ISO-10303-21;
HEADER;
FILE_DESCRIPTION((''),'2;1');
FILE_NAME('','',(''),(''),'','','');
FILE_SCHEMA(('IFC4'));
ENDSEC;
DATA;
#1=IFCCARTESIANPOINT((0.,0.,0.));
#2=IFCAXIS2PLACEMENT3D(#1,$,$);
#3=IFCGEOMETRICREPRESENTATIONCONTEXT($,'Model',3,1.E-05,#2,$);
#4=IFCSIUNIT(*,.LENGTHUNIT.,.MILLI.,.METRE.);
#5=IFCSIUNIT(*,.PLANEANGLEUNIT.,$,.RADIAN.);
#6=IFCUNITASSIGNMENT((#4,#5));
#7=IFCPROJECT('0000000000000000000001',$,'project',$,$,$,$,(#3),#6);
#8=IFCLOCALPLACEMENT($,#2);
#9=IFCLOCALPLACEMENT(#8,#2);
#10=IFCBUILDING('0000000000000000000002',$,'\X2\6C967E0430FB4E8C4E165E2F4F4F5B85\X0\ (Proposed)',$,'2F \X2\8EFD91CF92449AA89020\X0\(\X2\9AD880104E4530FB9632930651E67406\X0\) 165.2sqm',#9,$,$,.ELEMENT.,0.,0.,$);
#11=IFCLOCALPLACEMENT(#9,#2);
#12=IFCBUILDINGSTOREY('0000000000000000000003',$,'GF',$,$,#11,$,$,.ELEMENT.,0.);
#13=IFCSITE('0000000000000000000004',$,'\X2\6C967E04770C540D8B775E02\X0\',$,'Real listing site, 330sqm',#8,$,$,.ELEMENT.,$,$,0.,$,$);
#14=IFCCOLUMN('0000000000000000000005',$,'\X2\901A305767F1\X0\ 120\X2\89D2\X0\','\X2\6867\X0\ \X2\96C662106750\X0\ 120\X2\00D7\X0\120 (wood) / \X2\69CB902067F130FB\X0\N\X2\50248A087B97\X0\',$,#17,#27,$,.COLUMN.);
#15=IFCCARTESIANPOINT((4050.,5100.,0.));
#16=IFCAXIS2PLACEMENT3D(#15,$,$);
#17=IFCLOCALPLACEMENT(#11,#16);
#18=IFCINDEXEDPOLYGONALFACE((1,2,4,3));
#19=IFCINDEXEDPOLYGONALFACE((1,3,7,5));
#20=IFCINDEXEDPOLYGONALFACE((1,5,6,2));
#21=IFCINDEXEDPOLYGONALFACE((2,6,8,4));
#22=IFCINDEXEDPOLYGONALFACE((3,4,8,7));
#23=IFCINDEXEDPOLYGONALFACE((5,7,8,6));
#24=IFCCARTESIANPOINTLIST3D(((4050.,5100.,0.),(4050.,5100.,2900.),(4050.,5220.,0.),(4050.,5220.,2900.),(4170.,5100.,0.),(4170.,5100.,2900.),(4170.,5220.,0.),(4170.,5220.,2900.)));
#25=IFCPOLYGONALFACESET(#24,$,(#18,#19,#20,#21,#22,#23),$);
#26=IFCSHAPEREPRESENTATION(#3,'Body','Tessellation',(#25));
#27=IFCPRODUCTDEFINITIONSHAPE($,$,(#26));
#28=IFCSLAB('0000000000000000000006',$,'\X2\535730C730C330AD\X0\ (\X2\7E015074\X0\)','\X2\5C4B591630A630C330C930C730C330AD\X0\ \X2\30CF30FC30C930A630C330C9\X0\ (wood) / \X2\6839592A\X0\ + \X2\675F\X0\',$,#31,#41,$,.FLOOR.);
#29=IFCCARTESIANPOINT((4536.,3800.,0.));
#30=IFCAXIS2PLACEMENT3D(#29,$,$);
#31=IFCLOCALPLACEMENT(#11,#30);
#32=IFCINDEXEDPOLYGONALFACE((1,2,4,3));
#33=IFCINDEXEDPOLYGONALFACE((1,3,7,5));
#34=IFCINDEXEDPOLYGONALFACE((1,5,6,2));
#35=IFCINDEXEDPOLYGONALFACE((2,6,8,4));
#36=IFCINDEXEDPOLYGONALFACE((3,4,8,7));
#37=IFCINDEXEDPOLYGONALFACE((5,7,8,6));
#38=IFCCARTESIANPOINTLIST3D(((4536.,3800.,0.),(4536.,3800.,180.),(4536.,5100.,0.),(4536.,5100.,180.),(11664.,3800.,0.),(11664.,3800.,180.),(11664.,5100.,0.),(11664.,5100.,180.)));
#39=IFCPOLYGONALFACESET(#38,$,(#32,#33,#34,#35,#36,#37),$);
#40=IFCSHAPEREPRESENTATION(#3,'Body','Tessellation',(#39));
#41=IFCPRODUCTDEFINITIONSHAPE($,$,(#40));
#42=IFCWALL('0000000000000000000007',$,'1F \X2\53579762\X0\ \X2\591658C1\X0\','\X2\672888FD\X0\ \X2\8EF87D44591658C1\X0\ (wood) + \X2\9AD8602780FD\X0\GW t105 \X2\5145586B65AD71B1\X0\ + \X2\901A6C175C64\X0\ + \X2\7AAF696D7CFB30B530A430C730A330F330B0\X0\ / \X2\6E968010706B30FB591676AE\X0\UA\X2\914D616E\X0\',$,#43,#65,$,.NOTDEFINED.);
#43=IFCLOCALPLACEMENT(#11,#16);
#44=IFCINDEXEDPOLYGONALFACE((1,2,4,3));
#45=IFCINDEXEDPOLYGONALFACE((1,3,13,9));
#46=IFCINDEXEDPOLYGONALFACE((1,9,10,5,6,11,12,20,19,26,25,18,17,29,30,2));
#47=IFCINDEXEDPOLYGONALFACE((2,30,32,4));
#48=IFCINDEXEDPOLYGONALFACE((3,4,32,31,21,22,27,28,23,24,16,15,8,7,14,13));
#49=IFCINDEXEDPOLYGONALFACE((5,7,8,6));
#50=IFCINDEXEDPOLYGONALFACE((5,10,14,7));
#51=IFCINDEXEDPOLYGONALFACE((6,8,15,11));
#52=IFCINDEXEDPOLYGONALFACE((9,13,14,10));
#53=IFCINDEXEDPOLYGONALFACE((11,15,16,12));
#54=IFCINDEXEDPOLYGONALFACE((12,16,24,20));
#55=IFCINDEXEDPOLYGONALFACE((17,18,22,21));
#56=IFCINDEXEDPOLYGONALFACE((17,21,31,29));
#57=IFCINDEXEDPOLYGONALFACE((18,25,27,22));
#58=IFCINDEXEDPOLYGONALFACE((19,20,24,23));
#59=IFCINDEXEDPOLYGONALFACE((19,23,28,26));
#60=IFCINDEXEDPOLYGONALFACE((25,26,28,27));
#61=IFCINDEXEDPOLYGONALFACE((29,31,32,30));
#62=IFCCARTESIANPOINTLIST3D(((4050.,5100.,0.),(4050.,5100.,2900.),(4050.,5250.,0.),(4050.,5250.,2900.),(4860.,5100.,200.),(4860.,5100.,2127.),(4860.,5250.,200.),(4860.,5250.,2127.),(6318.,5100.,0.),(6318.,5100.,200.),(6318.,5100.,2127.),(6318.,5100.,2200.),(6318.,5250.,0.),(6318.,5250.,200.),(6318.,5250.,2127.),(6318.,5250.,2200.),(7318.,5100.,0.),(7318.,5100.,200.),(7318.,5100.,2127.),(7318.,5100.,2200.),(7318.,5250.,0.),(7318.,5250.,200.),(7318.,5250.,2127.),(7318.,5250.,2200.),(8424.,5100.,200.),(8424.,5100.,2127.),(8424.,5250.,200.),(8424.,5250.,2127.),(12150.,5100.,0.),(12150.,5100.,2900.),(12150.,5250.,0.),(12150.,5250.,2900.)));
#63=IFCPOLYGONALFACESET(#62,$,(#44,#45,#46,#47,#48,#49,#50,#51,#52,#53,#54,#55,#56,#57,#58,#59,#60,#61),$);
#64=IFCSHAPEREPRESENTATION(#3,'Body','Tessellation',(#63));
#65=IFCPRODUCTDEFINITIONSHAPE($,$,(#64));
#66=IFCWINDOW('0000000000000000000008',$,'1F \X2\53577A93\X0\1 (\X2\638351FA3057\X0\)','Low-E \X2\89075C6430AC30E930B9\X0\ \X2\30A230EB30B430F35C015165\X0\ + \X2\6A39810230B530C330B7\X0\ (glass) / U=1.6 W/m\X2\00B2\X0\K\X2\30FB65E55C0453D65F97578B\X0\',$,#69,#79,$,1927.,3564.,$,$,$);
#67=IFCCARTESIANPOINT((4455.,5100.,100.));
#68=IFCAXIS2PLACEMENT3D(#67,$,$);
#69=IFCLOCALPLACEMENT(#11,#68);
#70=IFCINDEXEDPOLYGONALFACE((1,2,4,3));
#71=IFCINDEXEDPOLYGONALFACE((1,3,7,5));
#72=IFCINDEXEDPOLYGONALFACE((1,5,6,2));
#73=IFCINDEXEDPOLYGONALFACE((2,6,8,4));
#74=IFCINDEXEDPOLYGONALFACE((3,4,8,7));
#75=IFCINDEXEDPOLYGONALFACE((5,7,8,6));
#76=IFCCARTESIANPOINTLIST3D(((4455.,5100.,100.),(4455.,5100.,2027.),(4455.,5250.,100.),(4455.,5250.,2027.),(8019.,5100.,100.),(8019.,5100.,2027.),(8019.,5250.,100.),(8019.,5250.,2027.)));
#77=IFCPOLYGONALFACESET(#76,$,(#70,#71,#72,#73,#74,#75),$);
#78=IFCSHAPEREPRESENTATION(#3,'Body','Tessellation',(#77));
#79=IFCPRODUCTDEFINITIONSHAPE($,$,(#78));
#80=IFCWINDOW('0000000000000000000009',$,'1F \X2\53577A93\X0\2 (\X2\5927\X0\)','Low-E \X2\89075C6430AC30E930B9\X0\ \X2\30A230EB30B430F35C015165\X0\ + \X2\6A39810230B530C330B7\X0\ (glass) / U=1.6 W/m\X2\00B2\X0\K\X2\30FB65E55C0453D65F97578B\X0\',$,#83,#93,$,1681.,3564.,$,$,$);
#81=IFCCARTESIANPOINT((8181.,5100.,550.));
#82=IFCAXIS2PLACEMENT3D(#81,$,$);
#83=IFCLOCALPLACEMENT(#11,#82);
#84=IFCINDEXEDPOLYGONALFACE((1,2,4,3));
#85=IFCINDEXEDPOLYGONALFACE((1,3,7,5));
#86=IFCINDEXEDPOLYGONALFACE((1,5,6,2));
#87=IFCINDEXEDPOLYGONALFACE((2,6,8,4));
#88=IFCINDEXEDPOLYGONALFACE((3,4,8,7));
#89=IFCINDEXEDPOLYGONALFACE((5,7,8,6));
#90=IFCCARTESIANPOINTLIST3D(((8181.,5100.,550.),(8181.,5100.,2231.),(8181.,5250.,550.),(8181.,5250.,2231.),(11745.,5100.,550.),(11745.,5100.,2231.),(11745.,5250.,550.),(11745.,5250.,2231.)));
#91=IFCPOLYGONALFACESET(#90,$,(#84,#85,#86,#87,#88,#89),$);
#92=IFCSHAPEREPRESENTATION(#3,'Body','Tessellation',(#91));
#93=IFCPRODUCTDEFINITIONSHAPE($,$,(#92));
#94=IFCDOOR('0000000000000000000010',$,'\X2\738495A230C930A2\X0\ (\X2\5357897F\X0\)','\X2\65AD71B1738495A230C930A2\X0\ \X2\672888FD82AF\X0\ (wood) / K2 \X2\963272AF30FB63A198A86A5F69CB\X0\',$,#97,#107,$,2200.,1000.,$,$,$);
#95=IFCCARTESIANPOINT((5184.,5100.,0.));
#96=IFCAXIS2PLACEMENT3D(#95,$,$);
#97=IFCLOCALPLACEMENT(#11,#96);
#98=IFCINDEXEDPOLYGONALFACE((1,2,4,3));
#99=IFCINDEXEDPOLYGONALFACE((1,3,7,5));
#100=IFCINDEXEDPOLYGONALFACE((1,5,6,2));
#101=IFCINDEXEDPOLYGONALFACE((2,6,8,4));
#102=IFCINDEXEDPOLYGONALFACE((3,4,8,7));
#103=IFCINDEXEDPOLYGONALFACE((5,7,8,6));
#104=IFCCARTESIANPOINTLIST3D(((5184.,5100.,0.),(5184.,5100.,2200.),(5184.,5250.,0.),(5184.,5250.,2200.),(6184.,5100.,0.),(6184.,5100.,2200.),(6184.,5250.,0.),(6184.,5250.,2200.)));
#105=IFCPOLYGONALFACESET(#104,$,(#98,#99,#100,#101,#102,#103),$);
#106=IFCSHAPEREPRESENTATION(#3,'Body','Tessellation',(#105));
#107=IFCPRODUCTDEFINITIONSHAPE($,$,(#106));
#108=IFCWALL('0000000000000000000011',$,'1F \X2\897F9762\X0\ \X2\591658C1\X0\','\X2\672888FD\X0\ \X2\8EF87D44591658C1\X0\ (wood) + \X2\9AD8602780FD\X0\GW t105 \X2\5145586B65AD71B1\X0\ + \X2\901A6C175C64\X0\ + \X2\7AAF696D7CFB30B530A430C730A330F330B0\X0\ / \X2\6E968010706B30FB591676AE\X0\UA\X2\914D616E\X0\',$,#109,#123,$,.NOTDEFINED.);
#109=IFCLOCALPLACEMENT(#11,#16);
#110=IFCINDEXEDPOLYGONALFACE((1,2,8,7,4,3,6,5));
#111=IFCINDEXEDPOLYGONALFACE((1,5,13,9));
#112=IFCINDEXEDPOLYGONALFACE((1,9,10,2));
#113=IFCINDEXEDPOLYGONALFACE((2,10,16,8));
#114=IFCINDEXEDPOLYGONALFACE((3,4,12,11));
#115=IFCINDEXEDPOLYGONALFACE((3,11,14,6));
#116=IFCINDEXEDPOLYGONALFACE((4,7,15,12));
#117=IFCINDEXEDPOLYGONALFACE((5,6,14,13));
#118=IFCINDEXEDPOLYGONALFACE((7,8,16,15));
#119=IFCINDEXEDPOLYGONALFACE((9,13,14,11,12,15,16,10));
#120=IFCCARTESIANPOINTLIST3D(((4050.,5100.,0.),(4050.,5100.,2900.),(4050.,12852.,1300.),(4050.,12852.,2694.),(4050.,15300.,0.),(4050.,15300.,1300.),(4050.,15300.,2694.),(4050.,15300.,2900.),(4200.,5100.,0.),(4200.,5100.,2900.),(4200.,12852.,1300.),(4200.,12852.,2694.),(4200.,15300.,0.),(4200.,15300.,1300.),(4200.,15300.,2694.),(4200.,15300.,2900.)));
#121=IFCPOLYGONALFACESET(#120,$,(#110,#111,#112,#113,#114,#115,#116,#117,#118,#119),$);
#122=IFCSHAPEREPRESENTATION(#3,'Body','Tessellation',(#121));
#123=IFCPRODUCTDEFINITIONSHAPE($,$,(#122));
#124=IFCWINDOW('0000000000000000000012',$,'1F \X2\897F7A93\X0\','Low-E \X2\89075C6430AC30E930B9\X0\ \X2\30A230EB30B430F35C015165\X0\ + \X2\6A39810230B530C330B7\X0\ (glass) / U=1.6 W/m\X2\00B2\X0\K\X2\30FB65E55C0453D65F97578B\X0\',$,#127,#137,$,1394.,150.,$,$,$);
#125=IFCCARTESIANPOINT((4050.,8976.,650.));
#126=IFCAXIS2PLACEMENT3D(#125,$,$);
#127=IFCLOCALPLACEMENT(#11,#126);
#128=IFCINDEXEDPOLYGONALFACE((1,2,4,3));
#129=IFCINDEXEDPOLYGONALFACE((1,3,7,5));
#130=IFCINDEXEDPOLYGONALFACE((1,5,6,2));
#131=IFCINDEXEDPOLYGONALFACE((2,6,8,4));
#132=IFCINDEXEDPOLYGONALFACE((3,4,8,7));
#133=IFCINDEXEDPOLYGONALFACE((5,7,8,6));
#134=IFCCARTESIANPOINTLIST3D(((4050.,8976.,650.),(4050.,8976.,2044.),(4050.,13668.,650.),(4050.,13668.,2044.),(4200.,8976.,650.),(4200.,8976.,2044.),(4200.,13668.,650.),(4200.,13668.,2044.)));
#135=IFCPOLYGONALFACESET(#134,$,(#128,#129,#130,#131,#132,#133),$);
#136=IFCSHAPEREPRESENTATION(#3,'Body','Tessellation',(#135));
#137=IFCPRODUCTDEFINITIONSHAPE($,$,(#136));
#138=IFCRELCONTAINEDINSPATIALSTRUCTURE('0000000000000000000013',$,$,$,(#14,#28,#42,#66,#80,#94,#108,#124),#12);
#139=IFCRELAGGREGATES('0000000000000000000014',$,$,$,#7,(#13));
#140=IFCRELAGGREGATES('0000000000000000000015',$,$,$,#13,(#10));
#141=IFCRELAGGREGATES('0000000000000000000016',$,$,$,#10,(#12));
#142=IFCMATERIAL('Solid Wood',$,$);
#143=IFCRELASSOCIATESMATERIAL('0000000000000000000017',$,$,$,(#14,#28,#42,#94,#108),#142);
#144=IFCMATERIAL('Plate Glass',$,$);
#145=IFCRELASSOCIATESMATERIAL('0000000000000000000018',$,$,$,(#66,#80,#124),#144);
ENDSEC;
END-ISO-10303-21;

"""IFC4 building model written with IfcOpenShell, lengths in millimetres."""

from ifc_helpers import new_model, si_unit, frame, frame_2d, origin, place, context, project, spatial, rectangle, extrude, material, element, fill, save


model = new_model("IFC4")

# Units and contexts
model_context = context("Model", 3, precision=1e-05, world=origin())
ifc_project = project(units=[si_unit("LENGTHUNIT", "METRE", prefix="MILLI"), si_unit("PLANEANGLEUNIT", "RADIAN")], contexts=[model_context])

# Site, building, storey
site_placement = place(None, origin())
site = spatial("IfcSite", under=ifc_project, at=site_placement, Name="沖縄県名護市", ObjectType="Real listing site, 330sqm", CompositionType="ELEMENT", RefElevation=0.0)
building_placement = place(site_placement, origin())
building = spatial("IfcBuilding", under=site, at=building_placement, Name="沖縄・二世帯住宅 (Proposed)", ObjectType="2F 軽量鉄骨造(高耐久・防錆処理) 165.2sqm", CompositionType="ELEMENT", ElevationOfRefHeight=0.0, ElevationOfTerrain=0.0)
storey_placement = place(building_placement, origin())
storey = spatial("IfcBuildingStorey", under=building, at=storey_placement, Name="GF", CompositionType="ELEMENT", Elevation=0.0)

# Column
ifc_material_1 = material(Name="Solid Wood")
column_placement = place(storey_placement, frame((4050.0, 5100.0, 0.0)))
element("IfcColumn", 1, at=column_placement, inside=storey, material=ifc_material_1, Name="通し柱 120角", Description="桧 集成材 120×120 (wood) / 構造柱・N値計算", PredefinedType="COLUMN", context=model_context, shape_type="SweptSolid", body=[
    extrude(rectangle(XDim=120.0, YDim=120.0, at=frame_2d((60.0, 60.0))), frame((4050.0, 5100.0, 0.0)), (0.0, 0.0, 1.0), 2900.0),
])

# Slab
slab_1_placement = place(storey_placement, frame((4536.0, 3800.0, 0.0)))
element("IfcSlab", 2, at=slab_1_placement, inside=storey, material=ifc_material_1, Name="南デッキ (縁側)", Description="屋外ウッドデッキ ハードウッド (wood) / 根太 + 束", PredefinedType="FLOOR", context=model_context, shape_type="SweptSolid", body=[
    extrude(rectangle(XDim=7128.0, YDim=1300.0, at=frame_2d((3564.0, 650.0))), frame((4536.0, 3800.0, 0.0)), (0.0, 0.0, 1.0), 180.0),
])

# Wall, openings, windows, door
wall_1_placement = place(storey_placement, frame((4050.0, 5100.0, 0.0)))
wall_1 = element("IfcWall", 3, at=wall_1_placement, inside=storey, material=ifc_material_1, Name="1F 南面 外壁", Description="木製 軸組外壁 (wood) + 高性能GW t105 充填断熱 + 通気層 + 窯業系サイディング / 準耐火・外皮UA配慮", PredefinedType="NOTDEFINED", context=model_context, shape_type="SweptSolid", body=[
    extrude(rectangle(XDim=8100.0, YDim=150.0, at=frame_2d((4050.0, 75.0))), frame((4050.0, 5100.0, 0.0)), (0.0, 0.0, 1.0), 2900.0),
])
opening_1_placement = place(storey_placement, frame((4455.0, 5100.0, 100.0)))
opening_1 = element("IfcOpeningElement", 4, at=opening_1_placement, cuts=wall_1, PredefinedType="NOTDEFINED", context=model_context, shape_type="SweptSolid", body=[
    extrude(rectangle(XDim=3564.0, YDim=150.0, at=frame_2d((1782.0, 75.0))), frame((4455.0, 5100.0, 100.0)), (0.0, 0.0, 1.0), 1927.0),
])
opening_2_placement = place(storey_placement, frame((8181.0, 5100.0, 550.0)))
opening_2 = element("IfcOpeningElement", 5, at=opening_2_placement, cuts=wall_1, PredefinedType="NOTDEFINED", context=model_context, shape_type="SweptSolid", body=[
    extrude(rectangle(XDim=3564.0, YDim=150.0, at=frame_2d((1782.0, 75.0))), frame((8181.0, 5100.0, 550.0)), (0.0, 0.0, 1.0), 1681.0),
])
opening_3_placement = place(storey_placement, frame((5184.0, 5100.0, 0.0)))
opening_3 = element("IfcOpeningElement", 6, at=opening_3_placement, cuts=wall_1, PredefinedType="NOTDEFINED", context=model_context, shape_type="SweptSolid", body=[
    extrude(rectangle(XDim=1000.0, YDim=150.0, at=frame_2d((500.0, 75.0))), frame((5184.0, 5100.0, 0.0)), (0.0, 0.0, 1.0), 2200.0),
])
ifc_material_2 = material(Name="Plate Glass")
window_1_placement = place(storey_placement, frame((4455.0, 5100.0, 100.0)))
window_1 = element("IfcWindow", 7, at=window_1_placement, inside=storey, material=ifc_material_2, Name="1F 南窓1 (掃出し)", Description="Low-E 複層ガラス アルゴン封入 + 樹脂サッシ (glass) / U=1.6 W/m²K・日射取得型", OverallHeight=1927.0, OverallWidth=3564.0, context=model_context, shape_type="SweptSolid", body=[
    extrude(rectangle(XDim=3564.0, YDim=150.0, at=frame_2d((1782.0, 75.0))), frame((4455.0, 5100.0, 100.0)), (0.0, 0.0, 1.0), 1927.0),
])
fill(opening_1, window_1)
window_2_placement = place(storey_placement, frame((8181.0, 5100.0, 550.0)))
window_2 = element("IfcWindow", 8, at=window_2_placement, inside=storey, material=ifc_material_2, Name="1F 南窓2 (大)", Description="Low-E 複層ガラス アルゴン封入 + 樹脂サッシ (glass) / U=1.6 W/m²K・日射取得型", OverallHeight=1681.0, OverallWidth=3564.0, context=model_context, shape_type="SweptSolid", body=[
    extrude(rectangle(XDim=3564.0, YDim=150.0, at=frame_2d((1782.0, 75.0))), frame((8181.0, 5100.0, 550.0)), (0.0, 0.0, 1.0), 1681.0),
])
fill(opening_2, window_2)
door_placement = place(storey_placement, frame((5184.0, 5100.0, 0.0)))
door = element("IfcDoor", 9, at=door_placement, inside=storey, material=ifc_material_1, Name="玄関ドア (南西)", Description="断熱玄関ドア 木製芯 (wood) / K2 防犯・採風機構", OverallHeight=2200.0, OverallWidth=1000.0, context=model_context, shape_type="SweptSolid", body=[
    extrude(rectangle(XDim=1000.0, YDim=150.0, at=frame_2d((500.0, 75.0))), frame((5184.0, 5100.0, 0.0)), (0.0, 0.0, 1.0), 2200.0),
])
fill(opening_3, door)

# Wall, opening, window
wall_2_placement = place(storey_placement, frame((4050.0, 5100.0, 0.0)))
wall_2 = element("IfcWall", 10, at=wall_2_placement, inside=storey, material=ifc_material_1, Name="1F 西面 外壁", Description="木製 軸組外壁 (wood) + 高性能GW t105 充填断熱 + 通気層 + 窯業系サイディング / 準耐火・外皮UA配慮", PredefinedType="NOTDEFINED", context=model_context, shape_type="SweptSolid", body=[
    extrude(rectangle(XDim=150.0, YDim=10200.0, at=frame_2d((75.0, 5100.0))), frame((4050.0, 5100.0, 0.0)), (0.0, 0.0, 1.0), 2900.0),
])
opening_4_placement = place(storey_placement, frame((4050.0, 8976.0, 650.0)))
opening_4 = element("IfcOpeningElement", 11, at=opening_4_placement, cuts=wall_2, PredefinedType="NOTDEFINED", context=model_context, shape_type="SweptSolid", body=[
    extrude(rectangle(XDim=150.0, YDim=4692.0, at=frame_2d((75.0, 2346.0))), frame((4050.0, 8976.0, 650.0)), (0.0, 0.0, 1.0), 1394.0),
])
window_3_placement = place(storey_placement, frame((4050.0, 8976.0, 650.0)))
window_3 = element("IfcWindow", 12, at=window_3_placement, inside=storey, material=ifc_material_2, Name="1F 西窓", Description="Low-E 複層ガラス アルゴン封入 + 樹脂サッシ (glass) / U=1.6 W/m²K・日射取得型", OverallHeight=1394.0, OverallWidth=150.0, context=model_context, shape_type="SweptSolid", body=[
    extrude(rectangle(XDim=150.0, YDim=4692.0, at=frame_2d((75.0, 2346.0))), frame((4050.0, 8976.0, 650.0)), (0.0, 0.0, 1.0), 1394.0),
])
fill(opening_4, window_3)

save(model, "model.ifc")
